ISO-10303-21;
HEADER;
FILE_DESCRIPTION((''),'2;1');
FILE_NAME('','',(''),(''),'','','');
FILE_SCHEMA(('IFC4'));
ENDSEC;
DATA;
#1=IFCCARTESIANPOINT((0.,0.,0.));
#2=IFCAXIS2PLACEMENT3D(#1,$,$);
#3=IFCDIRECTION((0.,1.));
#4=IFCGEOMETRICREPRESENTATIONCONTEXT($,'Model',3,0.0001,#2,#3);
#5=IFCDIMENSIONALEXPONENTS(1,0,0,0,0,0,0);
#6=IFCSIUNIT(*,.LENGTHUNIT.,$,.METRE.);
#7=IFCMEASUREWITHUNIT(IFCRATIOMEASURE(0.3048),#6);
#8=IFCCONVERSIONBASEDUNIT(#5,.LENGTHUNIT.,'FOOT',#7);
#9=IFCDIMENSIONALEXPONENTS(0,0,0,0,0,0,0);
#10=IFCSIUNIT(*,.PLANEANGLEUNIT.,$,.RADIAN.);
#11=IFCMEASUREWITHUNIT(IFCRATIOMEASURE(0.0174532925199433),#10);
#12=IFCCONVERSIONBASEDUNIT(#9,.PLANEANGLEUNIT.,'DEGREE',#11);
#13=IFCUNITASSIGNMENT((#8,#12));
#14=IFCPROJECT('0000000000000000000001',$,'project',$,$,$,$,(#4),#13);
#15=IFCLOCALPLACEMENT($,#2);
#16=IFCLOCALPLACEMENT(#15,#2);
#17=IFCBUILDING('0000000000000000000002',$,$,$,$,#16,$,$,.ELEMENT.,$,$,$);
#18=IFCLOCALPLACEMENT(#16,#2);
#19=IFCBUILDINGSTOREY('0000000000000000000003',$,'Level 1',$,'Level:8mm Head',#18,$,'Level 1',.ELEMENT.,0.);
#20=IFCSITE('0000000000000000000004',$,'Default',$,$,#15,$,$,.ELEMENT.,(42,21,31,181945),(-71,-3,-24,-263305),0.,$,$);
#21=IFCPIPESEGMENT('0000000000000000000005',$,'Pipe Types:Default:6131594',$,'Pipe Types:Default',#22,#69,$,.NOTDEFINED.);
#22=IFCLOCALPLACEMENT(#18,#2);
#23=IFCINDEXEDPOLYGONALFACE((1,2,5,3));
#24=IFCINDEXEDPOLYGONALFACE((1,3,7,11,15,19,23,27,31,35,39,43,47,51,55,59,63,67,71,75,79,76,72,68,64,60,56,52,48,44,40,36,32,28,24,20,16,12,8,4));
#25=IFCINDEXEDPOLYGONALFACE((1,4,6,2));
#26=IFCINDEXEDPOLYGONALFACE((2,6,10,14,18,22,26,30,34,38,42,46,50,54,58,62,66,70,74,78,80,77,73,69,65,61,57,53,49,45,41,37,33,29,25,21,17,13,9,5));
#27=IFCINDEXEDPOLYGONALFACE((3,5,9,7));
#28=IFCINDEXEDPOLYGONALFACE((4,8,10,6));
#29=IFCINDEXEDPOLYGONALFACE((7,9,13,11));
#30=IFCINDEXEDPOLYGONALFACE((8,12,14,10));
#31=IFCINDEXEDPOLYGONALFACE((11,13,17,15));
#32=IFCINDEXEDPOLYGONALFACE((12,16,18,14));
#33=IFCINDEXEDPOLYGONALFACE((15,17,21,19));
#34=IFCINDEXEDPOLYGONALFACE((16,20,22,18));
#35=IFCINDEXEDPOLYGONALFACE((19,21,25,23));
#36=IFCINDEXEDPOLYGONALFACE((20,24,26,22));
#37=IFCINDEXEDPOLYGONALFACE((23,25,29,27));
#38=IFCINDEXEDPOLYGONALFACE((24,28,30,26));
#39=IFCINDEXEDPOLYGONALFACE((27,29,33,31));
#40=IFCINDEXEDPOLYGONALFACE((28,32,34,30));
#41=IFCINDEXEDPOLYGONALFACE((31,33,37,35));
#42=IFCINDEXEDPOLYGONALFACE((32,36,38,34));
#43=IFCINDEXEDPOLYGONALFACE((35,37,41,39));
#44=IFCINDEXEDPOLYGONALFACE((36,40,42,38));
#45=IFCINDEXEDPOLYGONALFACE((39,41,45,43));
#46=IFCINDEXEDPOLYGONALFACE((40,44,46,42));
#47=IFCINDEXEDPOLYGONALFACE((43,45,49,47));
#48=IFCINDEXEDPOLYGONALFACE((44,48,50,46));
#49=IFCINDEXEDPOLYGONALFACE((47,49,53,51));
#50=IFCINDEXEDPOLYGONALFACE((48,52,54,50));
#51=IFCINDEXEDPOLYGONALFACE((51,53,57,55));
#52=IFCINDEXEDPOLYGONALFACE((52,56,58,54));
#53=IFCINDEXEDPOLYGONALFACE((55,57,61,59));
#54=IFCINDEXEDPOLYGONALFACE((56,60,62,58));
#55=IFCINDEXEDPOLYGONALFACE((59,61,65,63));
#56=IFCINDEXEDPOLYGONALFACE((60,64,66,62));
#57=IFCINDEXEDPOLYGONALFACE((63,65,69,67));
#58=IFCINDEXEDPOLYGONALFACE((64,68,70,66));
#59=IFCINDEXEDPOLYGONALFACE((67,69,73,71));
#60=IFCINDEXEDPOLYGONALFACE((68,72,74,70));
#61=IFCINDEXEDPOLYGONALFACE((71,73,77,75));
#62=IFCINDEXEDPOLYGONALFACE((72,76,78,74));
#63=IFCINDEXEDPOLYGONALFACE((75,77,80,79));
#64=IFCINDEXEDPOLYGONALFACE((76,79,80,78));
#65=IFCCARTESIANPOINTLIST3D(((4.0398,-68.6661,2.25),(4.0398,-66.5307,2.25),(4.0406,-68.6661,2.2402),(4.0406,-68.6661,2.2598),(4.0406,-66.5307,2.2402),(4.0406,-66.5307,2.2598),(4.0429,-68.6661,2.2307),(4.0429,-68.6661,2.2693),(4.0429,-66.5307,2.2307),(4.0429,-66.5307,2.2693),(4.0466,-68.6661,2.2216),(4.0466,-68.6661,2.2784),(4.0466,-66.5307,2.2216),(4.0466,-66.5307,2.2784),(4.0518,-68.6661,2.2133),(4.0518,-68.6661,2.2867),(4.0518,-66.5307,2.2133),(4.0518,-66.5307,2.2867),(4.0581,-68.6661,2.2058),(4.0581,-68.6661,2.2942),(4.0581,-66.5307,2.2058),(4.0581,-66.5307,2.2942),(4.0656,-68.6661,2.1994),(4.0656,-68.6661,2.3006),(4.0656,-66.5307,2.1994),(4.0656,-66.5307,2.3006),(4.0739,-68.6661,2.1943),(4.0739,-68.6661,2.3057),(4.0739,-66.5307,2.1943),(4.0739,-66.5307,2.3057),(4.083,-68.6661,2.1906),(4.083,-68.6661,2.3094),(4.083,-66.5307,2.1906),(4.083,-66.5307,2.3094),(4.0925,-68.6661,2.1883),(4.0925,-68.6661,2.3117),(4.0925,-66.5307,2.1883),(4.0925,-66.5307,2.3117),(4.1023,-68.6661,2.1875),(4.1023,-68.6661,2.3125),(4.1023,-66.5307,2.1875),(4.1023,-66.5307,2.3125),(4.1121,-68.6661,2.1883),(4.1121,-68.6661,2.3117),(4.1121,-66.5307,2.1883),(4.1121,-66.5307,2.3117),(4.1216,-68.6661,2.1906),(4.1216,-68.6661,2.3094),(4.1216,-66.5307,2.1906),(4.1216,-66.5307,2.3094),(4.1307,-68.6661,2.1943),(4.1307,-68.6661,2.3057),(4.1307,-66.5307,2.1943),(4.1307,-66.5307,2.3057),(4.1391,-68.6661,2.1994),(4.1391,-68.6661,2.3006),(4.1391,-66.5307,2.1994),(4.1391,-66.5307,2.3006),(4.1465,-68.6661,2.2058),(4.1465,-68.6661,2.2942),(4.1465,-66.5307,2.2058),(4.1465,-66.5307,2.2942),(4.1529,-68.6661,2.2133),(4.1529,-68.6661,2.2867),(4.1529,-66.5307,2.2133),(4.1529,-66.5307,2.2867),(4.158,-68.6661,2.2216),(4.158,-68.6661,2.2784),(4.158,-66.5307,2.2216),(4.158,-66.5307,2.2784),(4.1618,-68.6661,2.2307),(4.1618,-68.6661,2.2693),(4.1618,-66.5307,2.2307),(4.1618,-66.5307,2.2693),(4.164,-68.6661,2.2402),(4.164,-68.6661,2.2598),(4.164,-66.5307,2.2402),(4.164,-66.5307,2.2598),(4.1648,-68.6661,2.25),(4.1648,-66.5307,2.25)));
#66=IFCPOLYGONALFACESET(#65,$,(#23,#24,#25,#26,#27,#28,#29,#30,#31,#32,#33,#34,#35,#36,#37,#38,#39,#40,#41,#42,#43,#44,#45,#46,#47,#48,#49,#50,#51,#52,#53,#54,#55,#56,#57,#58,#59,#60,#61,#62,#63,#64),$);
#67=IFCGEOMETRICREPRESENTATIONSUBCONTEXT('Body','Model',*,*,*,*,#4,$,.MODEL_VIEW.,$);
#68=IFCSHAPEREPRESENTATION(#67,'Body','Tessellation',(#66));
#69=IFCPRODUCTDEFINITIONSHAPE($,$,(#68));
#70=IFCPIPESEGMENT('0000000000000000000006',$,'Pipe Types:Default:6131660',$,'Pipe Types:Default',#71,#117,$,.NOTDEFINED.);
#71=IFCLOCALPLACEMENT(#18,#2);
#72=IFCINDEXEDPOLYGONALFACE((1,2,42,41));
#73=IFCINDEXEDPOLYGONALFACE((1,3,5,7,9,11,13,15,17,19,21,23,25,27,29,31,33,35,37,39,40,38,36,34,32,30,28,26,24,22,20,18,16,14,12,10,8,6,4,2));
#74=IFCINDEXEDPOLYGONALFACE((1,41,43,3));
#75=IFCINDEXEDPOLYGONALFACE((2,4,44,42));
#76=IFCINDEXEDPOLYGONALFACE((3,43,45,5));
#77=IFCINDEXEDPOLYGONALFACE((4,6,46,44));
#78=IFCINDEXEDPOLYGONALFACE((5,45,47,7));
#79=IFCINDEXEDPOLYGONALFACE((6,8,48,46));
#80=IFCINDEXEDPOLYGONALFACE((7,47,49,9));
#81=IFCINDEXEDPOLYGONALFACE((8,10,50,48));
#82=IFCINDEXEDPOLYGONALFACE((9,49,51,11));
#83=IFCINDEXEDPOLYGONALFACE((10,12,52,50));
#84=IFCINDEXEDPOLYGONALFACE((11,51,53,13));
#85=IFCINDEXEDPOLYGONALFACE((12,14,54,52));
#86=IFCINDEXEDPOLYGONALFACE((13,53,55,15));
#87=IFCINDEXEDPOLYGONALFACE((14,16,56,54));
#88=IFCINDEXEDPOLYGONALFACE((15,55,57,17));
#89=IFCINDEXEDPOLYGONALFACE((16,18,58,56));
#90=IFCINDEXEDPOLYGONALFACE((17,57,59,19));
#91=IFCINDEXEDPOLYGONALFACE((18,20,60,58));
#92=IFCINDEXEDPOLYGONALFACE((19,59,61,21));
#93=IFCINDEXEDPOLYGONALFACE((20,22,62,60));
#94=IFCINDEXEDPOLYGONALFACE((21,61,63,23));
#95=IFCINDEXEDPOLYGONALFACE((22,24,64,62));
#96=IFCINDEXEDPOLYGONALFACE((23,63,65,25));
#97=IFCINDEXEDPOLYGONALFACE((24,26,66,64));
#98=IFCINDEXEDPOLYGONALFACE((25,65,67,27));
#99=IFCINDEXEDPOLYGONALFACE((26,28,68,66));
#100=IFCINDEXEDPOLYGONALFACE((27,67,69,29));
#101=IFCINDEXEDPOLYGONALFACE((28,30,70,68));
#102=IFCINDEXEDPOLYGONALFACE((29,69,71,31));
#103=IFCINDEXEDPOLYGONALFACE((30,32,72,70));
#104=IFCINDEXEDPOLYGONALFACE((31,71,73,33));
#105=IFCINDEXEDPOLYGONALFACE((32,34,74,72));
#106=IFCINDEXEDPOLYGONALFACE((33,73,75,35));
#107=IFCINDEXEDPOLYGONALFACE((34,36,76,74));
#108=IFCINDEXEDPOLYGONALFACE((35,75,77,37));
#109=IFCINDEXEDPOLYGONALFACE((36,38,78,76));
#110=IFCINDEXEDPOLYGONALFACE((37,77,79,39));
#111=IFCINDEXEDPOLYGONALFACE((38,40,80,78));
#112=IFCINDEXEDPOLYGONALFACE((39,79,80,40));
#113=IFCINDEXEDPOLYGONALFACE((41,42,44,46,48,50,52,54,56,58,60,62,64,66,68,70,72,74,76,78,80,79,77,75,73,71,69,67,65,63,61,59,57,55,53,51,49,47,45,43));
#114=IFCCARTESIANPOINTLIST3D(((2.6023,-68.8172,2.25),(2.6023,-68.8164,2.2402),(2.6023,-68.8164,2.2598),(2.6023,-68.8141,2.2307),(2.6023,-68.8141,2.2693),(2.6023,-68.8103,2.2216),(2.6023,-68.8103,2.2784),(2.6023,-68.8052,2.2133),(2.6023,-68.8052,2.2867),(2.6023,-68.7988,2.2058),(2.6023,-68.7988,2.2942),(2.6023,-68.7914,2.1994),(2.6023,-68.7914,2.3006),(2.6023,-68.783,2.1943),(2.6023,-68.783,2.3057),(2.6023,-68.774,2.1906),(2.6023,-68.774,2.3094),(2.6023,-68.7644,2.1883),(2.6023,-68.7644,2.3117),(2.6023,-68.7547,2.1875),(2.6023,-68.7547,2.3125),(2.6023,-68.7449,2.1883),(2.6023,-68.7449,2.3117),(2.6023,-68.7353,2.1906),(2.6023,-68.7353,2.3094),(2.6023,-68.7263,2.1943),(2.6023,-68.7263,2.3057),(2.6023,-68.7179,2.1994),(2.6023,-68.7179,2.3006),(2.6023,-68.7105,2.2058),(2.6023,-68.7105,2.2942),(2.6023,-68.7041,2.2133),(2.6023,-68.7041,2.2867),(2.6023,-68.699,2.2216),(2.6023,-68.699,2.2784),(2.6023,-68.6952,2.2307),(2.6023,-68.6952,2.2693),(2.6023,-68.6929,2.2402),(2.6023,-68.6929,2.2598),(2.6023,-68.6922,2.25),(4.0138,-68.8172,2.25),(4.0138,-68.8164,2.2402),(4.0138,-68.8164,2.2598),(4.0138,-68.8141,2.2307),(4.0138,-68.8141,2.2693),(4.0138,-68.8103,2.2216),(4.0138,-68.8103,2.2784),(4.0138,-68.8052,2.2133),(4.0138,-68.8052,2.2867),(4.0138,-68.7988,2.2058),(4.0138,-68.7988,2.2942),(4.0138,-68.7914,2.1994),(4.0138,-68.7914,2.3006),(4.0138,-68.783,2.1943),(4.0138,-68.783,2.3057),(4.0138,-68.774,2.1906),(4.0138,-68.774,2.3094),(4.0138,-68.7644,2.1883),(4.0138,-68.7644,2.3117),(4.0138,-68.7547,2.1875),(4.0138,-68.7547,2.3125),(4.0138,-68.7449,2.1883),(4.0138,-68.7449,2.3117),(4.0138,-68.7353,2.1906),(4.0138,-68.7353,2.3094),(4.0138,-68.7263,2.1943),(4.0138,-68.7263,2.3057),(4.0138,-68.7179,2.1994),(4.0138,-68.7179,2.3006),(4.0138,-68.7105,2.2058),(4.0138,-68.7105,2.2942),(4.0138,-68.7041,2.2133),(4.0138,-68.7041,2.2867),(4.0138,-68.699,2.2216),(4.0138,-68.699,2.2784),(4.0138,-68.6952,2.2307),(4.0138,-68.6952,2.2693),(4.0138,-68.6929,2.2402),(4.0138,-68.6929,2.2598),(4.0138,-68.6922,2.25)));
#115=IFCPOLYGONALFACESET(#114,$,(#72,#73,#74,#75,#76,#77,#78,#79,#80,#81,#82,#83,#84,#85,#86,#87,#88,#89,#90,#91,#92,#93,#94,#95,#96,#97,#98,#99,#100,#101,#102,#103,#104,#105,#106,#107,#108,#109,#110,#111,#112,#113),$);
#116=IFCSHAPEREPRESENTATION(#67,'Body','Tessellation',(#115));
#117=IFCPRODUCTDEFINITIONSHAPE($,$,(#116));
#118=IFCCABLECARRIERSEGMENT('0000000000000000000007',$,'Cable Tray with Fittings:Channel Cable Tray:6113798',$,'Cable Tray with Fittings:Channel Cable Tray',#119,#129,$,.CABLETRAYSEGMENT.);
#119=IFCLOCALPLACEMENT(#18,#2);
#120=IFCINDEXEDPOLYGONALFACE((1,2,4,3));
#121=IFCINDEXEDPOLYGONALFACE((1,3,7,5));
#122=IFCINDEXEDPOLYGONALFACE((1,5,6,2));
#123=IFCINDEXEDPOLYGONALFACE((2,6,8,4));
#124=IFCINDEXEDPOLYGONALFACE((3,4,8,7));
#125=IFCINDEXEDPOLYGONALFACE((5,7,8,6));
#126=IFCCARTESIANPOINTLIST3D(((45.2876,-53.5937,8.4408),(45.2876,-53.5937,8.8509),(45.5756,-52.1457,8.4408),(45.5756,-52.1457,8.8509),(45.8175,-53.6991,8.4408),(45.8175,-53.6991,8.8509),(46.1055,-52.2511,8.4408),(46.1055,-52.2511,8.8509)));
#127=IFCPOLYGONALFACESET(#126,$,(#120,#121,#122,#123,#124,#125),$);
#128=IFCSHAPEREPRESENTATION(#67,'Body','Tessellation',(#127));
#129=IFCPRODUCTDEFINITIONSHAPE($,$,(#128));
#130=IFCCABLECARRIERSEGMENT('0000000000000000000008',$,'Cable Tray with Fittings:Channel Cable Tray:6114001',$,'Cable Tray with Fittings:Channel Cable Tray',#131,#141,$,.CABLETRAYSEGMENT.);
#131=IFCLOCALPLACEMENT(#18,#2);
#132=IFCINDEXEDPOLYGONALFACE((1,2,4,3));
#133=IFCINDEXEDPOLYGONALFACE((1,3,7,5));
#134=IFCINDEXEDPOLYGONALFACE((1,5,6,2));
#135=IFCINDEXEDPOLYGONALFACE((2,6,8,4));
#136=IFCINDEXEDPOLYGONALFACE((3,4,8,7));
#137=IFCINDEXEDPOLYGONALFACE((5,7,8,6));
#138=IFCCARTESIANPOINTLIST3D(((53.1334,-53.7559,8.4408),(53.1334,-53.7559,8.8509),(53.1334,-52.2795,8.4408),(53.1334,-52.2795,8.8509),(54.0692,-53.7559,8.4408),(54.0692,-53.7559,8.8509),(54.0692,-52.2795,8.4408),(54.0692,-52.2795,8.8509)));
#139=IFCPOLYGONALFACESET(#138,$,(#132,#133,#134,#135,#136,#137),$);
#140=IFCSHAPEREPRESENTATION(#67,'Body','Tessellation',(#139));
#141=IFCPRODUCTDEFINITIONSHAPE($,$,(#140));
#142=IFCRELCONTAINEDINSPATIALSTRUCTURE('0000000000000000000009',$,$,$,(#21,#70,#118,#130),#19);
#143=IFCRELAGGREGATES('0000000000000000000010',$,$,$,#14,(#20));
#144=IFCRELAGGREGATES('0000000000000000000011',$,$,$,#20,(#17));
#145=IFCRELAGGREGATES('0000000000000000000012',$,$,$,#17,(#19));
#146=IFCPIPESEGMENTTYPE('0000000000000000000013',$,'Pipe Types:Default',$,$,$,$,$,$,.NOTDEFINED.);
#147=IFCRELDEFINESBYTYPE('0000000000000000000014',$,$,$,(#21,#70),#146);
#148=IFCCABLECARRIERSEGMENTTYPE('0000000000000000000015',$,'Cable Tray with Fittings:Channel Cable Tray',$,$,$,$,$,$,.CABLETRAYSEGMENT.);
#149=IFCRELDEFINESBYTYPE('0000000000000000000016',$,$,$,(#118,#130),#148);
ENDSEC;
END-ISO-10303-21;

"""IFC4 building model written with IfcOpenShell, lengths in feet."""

from ifc_helpers import new_model, entity, si_unit, converted_unit, direction, frame, origin, place, context, subcontext, project, spatial, indexed_curve, outline, extrude, type_object, element, save


model = new_model("IFC4")

# Units and contexts
model_context = context("Model", 3, precision=0.0001, world=origin(), true_north=direction((0.0, 1.0)))
body_context = subcontext(model_context, "Body", "Model", "MODEL_VIEW")
ifc_project = project(units=[converted_unit("LENGTHUNIT", "FOOT", entity("IfcRatioMeasure", 0.3048), si_unit("LENGTHUNIT", "METRE"), dimensions=[1, 0, 0, 0, 0, 0, 0]), converted_unit("PLANEANGLEUNIT", "DEGREE", entity("IfcRatioMeasure", 0.0174532925199433), si_unit("PLANEANGLEUNIT", "RADIAN"), dimensions=[0, 0, 0, 0, 0, 0, 0])], contexts=[model_context])

# Site, building, storey
site_placement = place(None, origin())
site = spatial("IfcSite", under=ifc_project, at=site_placement, Name="Default", CompositionType="ELEMENT", RefLatitude=(42, 21, 31, 181945), RefLongitude=(-71, -3, -24, -263305), RefElevation=0.0)
building_placement = place(site_placement, origin())
building = spatial("IfcBuilding", under=site, at=building_placement, CompositionType="ELEMENT")
storey_placement = place(building_placement, origin())
storey = spatial("IfcBuildingStorey", under=building, at=storey_placement, Name="Level 1", ObjectType="Level:8mm Head", LongName="Level 1", CompositionType="ELEMENT", Elevation=0.0)

# Pipe segments
pipe_segment_type = type_object("IfcPipeSegmentType", Name="Pipe Types:Default", PredefinedType="NOTDEFINED")
pipe_segment_1_placement = place(storey_placement, origin())
element("IfcPipeSegment", 1, at=pipe_segment_1_placement, inside=storey, type_object=pipe_segment_type, Name="Pipe Types:Default:6131594", ObjectType="Pipe Types:Default", PredefinedType="NOTDEFINED", context=body_context, shape_type="SweptSolid", body=[
    extrude(outline(indexed_curve([(0.0625, 0.0), (0.0617, 0.0098), (0.0594, 0.0193), (0.0557, 0.0284), (0.0506, 0.0367), (0.0442, 0.0442), (0.0367, 0.0506), (0.0284, 0.0557), (0.0193, 0.0594), (0.0098, 0.0617), (0.0, 0.0625), (-0.0098, 0.0617), (-0.0193, 0.0594), (-0.0284, 0.0557), (-0.0367, 0.0506), (-0.0442, 0.0442), (-0.0506, 0.0367), (-0.0557, 0.0284), (-0.0594, 0.0193), (-0.0617, 0.0098), (-0.0625, 0.0), (-0.0617, -0.0098), (-0.0594, -0.0193), (-0.0557, -0.0284), (-0.0506, -0.0367), (-0.0442, -0.0442), (-0.0367, -0.0506), (-0.0284, -0.0557), (-0.0193, -0.0594), (-0.0098, -0.0617), (0.0, -0.0625), (0.0098, -0.0617), (0.0193, -0.0594), (0.0284, -0.0557), (0.0367, -0.0506), (0.0442, -0.0442), (0.0506, -0.0367), (0.0557, -0.0284), (0.0594, -0.0193), (0.0617, -0.0098), (0.0625, 0.0)], self_intersect=False)), frame((4.1023, -68.6661, 2.25), z_axis=(0.0, 1.0, 0.0), x_axis=(-1.0, 0.0, 0.0)), (0.0, 0.0, 1.0), 2.1354),
])
pipe_segment_2_placement = place(storey_placement, origin())
element("IfcPipeSegment", 2, at=pipe_segment_2_placement, inside=storey, type_object=pipe_segment_type, Name="Pipe Types:Default:6131660", ObjectType="Pipe Types:Default", PredefinedType="NOTDEFINED", context=body_context, shape_type="SweptSolid", body=[
    extrude(outline(indexed_curve([(0.0625, 0.0), (0.0617, 0.0098), (0.0594, 0.0193), (0.0557, 0.0284), (0.0506, 0.0367), (0.0442, 0.0442), (0.0367, 0.0506), (0.0284, 0.0557), (0.0193, 0.0594), (0.0098, 0.0617), (0.0, 0.0625), (-0.0098, 0.0617), (-0.0193, 0.0594), (-0.0284, 0.0557), (-0.0367, 0.0506), (-0.0442, 0.0442), (-0.0506, 0.0367), (-0.0557, 0.0284), (-0.0594, 0.0193), (-0.0617, 0.0098), (-0.0625, 0.0), (-0.0617, -0.0098), (-0.0594, -0.0193), (-0.0557, -0.0284), (-0.0506, -0.0367), (-0.0442, -0.0442), (-0.0367, -0.0506), (-0.0284, -0.0557), (-0.0193, -0.0594), (-0.0098, -0.0617), (0.0, -0.0625), (0.0098, -0.0617), (0.0193, -0.0594), (0.0284, -0.0557), (0.0367, -0.0506), (0.0442, -0.0442), (0.0506, -0.0367), (0.0557, -0.0284), (0.0594, -0.0193), (0.0617, -0.0098), (0.0625, 0.0)], self_intersect=False)), frame((2.6023, -68.7547, 2.25), z_axis=(1.0, 0.0, 0.0), x_axis=(0.0, 1.0, 0.0)), (0.0, 0.0, 1.0), 1.4115),
])

# Cable carrier segments
cable_carrier_segment_type_1 = type_object("IfcCableCarrierSegmentType", Name="Cable Tray with Fittings:Channel Cable Tray", PredefinedType="CABLETRAYSEGMENT")
cable_carrier_segment_1_placement = place(storey_placement, origin())
element("IfcCableCarrierSegment", 3, at=cable_carrier_segment_1_placement, inside=storey, type_object=cable_carrier_segment_type_1, Name="Cable Tray with Fittings:Channel Cable Tray:6113798", ObjectType="Cable Tray with Fittings:Channel Cable Tray", PredefinedType="CABLETRAYSEGMENT", context=body_context, shape_type="SweptSolid", body=[
    extrude(outline(indexed_curve([(-0.2702, -0.7382), (0.2702, -0.7382), (0.2702, 0.7382), (-0.2702, 0.7382), (-0.2702, -0.7382)], self_intersect=False)), frame((45.6965, -52.9224, 8.4408), z_axis=(0.0, 0.0, 1.0), x_axis=(0.980785, -0.195091, 0.0)), (0.0, 0.0, 1.0), 0.4101),
])
cable_carrier_segment_2_placement = place(storey_placement, origin())
element("IfcCableCarrierSegment", 4, at=cable_carrier_segment_2_placement, inside=storey, type_object=cable_carrier_segment_type_1, Name="Cable Tray with Fittings:Channel Cable Tray:6114001", ObjectType="Cable Tray with Fittings:Channel Cable Tray", PredefinedType="CABLETRAYSEGMENT", context=body_context, shape_type="SweptSolid", body=[
    extrude(outline(indexed_curve([(-0.4679, -0.7382), (0.4679, -0.7382), (0.4679, 0.7382), (-0.4679, 0.7382), (-0.4679, -0.7382)], self_intersect=False)), frame((53.6013, -53.0177, 8.4408)), (0.0, 0.0, 1.0), 0.4101),
])

save(model, "model.ifc")
